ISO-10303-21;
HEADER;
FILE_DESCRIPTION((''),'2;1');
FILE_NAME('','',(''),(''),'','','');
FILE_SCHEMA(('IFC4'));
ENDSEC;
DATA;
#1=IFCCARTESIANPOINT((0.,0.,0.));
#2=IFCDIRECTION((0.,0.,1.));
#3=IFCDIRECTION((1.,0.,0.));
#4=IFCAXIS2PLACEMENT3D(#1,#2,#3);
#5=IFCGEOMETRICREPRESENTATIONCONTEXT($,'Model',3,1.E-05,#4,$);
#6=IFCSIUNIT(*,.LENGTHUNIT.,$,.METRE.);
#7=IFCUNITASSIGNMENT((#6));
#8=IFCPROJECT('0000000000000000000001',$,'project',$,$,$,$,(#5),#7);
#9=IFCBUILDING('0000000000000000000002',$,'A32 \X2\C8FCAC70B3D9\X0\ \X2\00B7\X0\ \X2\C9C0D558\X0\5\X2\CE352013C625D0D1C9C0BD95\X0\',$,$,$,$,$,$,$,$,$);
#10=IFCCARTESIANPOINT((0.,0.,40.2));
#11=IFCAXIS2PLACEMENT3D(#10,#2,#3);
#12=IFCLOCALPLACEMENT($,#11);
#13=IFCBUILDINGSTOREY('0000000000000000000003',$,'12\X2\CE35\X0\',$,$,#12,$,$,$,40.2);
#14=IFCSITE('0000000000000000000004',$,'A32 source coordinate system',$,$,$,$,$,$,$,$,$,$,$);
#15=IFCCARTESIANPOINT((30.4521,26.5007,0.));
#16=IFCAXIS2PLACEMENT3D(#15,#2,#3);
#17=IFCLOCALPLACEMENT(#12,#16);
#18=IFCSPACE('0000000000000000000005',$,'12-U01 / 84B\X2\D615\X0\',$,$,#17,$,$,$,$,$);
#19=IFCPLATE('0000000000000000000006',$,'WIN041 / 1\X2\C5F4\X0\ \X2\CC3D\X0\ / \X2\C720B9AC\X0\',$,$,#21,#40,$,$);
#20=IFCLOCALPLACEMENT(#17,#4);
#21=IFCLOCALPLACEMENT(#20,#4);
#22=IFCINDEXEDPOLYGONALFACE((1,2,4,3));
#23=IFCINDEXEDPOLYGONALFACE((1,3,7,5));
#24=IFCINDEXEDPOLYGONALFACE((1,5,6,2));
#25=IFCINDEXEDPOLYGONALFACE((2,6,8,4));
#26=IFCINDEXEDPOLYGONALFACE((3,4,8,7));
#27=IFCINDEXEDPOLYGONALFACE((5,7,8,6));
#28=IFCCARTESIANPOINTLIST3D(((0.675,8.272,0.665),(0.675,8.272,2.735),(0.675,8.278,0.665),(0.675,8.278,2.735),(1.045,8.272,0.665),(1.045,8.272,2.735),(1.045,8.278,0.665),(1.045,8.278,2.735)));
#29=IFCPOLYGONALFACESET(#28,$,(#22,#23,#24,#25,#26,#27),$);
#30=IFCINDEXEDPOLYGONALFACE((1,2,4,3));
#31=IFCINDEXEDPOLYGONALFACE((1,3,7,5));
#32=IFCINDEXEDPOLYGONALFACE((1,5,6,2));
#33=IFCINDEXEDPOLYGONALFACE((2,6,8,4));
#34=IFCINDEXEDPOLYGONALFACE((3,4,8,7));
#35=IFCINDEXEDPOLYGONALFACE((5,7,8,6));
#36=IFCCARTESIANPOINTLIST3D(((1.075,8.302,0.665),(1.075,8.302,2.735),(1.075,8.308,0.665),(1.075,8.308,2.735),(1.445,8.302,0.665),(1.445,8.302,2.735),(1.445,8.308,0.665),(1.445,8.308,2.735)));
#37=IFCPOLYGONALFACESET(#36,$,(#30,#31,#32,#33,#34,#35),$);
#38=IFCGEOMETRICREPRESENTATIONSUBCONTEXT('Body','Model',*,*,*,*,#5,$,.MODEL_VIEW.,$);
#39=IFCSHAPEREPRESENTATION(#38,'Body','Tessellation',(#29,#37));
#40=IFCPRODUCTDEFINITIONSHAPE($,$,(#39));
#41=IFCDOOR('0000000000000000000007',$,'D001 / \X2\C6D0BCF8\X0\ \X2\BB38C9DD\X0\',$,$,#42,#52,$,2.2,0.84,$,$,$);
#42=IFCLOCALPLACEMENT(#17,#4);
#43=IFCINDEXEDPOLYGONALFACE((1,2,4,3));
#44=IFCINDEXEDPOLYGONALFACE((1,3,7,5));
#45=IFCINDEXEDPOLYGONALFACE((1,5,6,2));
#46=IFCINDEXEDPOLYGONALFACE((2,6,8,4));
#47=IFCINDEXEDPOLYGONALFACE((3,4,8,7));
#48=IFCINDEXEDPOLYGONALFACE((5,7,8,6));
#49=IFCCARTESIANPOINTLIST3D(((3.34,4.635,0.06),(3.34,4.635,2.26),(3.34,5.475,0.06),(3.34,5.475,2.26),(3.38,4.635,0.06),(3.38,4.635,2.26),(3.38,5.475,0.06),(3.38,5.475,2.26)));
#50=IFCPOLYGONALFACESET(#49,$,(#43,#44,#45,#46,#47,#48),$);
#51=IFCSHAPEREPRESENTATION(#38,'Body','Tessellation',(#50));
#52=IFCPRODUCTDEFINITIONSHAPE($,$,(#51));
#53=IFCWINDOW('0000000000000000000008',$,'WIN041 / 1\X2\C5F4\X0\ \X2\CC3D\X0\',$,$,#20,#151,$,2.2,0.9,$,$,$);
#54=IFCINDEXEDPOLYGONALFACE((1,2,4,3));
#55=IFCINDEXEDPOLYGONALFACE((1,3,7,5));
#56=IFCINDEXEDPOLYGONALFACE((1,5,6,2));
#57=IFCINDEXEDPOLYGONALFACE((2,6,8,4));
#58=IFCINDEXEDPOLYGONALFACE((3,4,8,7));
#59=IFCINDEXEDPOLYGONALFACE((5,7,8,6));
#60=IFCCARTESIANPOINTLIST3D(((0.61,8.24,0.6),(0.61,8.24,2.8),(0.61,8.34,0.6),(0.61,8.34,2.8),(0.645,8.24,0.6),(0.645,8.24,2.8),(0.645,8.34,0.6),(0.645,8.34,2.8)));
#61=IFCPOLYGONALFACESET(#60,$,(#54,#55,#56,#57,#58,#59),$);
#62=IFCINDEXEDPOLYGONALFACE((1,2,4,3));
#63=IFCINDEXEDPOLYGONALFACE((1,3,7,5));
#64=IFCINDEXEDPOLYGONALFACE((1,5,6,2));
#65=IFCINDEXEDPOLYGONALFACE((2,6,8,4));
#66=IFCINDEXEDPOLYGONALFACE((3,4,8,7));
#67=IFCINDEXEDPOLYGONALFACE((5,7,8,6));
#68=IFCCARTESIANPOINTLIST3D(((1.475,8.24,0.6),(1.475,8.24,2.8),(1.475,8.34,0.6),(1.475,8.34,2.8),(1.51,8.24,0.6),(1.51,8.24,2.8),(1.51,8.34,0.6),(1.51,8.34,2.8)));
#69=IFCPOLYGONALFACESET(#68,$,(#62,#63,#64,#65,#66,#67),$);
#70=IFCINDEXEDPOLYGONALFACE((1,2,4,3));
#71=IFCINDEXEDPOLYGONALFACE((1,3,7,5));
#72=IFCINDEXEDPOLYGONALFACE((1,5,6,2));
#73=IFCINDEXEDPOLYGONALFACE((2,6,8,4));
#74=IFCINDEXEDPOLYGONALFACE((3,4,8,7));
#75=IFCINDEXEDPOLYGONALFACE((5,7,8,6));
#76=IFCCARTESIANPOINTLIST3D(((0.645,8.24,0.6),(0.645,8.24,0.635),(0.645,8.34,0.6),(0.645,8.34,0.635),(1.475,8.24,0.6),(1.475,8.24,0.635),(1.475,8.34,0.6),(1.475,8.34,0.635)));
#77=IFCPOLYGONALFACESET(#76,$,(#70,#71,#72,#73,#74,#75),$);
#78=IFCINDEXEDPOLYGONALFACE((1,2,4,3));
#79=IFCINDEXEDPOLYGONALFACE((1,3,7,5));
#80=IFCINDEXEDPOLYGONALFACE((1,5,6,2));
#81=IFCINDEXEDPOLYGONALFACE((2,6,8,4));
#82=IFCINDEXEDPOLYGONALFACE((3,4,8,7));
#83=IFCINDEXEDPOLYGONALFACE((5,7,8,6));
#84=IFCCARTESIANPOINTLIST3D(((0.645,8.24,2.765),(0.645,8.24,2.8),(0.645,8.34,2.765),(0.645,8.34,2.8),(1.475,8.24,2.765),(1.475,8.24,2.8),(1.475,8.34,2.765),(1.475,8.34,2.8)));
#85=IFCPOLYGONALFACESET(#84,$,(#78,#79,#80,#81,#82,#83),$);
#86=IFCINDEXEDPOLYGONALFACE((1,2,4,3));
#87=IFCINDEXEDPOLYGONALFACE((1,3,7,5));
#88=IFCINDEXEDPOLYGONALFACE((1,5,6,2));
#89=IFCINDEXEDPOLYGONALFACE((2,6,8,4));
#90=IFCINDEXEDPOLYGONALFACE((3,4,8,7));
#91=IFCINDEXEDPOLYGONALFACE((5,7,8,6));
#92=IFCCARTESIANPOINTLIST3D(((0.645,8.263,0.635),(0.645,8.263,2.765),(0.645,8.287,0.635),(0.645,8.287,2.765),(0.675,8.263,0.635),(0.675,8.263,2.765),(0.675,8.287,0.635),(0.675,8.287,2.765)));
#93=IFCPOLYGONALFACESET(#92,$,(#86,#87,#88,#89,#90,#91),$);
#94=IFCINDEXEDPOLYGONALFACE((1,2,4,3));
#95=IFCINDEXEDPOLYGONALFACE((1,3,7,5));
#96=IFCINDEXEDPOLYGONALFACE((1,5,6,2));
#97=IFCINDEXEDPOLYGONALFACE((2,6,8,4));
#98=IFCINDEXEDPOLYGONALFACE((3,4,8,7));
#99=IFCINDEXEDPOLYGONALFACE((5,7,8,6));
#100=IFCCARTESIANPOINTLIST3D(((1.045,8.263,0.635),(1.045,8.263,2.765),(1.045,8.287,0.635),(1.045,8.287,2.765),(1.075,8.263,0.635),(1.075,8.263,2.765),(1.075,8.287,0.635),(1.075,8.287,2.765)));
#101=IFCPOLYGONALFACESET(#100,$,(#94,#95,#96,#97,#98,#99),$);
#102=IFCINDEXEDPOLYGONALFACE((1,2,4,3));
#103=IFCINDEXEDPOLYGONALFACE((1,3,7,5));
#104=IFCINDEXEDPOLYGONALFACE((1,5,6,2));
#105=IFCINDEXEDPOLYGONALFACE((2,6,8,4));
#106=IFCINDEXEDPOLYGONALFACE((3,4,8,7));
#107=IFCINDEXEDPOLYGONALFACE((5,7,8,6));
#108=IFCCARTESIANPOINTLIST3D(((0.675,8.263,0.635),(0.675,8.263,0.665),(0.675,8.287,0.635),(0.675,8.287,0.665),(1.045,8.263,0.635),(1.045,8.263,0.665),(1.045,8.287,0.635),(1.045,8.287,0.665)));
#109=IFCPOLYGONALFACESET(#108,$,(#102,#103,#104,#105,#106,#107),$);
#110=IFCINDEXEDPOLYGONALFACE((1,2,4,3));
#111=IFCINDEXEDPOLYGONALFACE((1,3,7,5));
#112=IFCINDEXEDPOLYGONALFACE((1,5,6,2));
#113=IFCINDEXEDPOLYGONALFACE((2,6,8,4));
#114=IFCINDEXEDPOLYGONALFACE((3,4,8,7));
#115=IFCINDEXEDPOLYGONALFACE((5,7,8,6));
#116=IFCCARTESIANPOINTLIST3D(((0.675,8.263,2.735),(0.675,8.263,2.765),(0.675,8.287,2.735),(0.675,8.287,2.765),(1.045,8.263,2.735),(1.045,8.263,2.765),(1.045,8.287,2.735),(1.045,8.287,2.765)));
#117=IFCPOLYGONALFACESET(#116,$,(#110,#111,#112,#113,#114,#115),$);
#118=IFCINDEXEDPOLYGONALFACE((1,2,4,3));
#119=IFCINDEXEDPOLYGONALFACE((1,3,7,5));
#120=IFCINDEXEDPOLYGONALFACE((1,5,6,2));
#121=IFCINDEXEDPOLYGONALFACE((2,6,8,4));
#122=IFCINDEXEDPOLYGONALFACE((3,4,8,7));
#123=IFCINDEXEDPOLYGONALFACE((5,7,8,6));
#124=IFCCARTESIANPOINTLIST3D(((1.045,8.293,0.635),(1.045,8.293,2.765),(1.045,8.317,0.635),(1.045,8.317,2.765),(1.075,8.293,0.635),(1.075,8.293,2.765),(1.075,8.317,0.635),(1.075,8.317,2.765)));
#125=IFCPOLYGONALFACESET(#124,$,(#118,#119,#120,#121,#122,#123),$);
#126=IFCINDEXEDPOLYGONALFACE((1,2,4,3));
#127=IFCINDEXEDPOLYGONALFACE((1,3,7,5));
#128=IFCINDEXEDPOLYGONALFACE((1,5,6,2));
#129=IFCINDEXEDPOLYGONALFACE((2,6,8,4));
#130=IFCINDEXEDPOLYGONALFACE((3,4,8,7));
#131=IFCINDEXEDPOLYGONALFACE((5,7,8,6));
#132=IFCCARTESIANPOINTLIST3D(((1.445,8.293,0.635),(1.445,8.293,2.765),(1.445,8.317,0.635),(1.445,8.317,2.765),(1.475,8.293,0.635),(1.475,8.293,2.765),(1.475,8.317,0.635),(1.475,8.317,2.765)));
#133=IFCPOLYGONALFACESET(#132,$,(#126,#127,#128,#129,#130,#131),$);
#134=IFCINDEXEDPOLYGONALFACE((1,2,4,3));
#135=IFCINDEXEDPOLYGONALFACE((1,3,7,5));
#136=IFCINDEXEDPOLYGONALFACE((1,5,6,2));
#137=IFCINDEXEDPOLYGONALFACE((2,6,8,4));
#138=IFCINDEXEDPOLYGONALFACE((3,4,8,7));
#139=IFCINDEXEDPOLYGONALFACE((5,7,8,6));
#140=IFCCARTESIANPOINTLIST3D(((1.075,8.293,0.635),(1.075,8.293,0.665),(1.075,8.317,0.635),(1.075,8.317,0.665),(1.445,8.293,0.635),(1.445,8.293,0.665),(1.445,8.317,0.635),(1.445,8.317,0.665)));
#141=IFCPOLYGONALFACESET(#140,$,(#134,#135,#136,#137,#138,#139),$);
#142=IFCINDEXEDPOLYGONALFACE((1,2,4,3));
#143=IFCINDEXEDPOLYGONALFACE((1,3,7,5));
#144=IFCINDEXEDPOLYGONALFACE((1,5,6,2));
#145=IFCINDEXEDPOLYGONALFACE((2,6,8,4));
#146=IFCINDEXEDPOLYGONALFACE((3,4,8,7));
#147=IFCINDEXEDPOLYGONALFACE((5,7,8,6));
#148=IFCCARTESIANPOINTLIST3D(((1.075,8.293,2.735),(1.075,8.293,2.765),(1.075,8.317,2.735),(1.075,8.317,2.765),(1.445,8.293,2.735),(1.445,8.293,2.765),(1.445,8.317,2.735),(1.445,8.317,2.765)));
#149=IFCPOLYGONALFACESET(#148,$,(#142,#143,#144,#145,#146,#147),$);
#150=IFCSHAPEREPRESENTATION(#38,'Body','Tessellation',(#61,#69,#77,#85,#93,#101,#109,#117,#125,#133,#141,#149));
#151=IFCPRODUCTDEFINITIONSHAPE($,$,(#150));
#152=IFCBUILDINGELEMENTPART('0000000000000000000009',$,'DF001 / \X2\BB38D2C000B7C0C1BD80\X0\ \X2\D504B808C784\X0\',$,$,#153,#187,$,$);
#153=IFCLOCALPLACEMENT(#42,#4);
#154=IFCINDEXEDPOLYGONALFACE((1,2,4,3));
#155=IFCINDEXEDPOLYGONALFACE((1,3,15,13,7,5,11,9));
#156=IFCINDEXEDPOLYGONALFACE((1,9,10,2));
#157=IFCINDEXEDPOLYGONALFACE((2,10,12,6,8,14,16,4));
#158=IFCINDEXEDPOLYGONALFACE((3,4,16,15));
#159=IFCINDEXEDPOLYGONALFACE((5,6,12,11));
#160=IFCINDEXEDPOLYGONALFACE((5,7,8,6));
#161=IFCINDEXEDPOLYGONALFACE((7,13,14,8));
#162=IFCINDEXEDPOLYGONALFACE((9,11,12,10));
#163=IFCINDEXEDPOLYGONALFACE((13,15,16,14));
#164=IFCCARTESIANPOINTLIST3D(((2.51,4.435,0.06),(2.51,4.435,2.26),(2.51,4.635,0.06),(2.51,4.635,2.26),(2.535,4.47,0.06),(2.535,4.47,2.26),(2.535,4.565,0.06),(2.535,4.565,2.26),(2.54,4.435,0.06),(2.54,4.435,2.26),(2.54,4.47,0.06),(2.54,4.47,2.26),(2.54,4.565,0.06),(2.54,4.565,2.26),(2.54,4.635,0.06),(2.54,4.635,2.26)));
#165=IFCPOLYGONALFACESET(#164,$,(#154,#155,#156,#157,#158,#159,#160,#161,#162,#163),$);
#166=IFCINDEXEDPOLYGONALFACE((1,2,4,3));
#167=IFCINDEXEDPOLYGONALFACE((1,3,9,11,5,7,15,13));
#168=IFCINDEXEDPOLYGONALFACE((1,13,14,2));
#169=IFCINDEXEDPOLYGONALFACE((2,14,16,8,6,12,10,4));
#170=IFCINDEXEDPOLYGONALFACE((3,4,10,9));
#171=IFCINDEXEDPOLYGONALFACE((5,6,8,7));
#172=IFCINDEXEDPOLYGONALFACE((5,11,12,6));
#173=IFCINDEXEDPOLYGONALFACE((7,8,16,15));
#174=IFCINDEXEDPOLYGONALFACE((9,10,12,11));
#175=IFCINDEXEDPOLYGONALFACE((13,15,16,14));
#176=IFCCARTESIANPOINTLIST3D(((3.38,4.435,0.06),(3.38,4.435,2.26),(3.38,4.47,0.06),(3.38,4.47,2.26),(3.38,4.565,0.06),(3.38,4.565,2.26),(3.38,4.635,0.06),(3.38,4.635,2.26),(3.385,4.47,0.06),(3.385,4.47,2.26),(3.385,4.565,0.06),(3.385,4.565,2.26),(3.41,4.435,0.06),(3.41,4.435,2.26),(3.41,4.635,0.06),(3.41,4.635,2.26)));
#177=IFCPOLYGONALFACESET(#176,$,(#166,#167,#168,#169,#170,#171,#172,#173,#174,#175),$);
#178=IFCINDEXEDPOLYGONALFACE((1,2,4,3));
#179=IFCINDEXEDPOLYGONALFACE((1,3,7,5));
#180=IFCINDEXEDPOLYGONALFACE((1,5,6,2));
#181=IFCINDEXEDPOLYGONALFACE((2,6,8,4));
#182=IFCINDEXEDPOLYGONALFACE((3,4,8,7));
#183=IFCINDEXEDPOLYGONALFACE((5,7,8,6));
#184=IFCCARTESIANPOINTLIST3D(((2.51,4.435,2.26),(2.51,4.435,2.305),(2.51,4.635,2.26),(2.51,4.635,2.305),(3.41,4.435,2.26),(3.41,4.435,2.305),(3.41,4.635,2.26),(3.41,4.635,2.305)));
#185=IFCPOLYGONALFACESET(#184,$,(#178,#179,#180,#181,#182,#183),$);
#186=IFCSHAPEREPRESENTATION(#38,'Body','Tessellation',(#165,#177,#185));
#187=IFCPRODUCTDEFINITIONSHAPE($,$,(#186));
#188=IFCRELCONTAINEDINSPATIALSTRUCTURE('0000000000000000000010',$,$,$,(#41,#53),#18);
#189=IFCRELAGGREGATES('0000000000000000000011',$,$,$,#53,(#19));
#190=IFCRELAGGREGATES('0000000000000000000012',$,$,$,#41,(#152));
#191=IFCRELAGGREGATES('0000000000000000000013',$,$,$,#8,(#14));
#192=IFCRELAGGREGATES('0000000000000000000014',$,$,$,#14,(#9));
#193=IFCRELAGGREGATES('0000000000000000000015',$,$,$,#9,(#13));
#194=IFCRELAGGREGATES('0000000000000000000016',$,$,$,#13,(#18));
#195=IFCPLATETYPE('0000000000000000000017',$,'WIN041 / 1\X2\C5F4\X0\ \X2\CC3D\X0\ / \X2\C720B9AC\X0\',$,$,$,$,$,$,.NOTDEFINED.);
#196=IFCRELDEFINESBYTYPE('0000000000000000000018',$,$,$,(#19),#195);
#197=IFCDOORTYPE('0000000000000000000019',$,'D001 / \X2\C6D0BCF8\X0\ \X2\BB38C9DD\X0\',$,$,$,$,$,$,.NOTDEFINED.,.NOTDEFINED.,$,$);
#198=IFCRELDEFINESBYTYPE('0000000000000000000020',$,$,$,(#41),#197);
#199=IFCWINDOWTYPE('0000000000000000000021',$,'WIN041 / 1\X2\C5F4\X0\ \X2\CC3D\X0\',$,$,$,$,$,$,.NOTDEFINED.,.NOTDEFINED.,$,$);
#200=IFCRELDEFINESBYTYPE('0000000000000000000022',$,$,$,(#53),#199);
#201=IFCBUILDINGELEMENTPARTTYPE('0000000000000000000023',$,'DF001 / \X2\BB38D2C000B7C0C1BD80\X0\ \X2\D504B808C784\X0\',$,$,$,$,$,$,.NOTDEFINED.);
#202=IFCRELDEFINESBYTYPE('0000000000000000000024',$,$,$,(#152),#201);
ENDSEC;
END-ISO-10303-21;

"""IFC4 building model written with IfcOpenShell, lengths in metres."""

from ifc_helpers import new_model, si_unit, frame, origin, origin_with_axes, place, context, subcontext, project, spatial, polyline, outline, extrude, source, transform, mapped, type_object, type_shapes, element, aggregate, save


model = new_model("IFC4")

# Units and contexts
model_context = context("Model", 3, precision=1e-05, world=origin_with_axes())
body_context = subcontext(model_context, "Body", "Model", "MODEL_VIEW")
ifc_project = project(units=[si_unit("LENGTHUNIT", "METRE")], contexts=[model_context])

# Plate
storey_placement = place(None, frame((0.0, 0.0, 40.2), z_axis=(0.0, 0.0, 1.0), x_axis=(1.0, 0.0, 0.0)))
space_placement = place(storey_placement, frame((30.4521, 26.5007, 0.0), z_axis=(0.0, 0.0, 1.0), x_axis=(1.0, 0.0, 0.0)))
plate_type_1 = type_object("IfcPlateType", Name="WIN041 / 1열 창 / 유리", PredefinedType="NOTDEFINED")
shared_shape_1 = source(origin(), body_context, "Body", "SweptSolid", [
    extrude(outline(polyline([(0.675, 8.272), (0.675, 8.278), (1.045, 8.278), (1.045, 8.272), (0.675, 8.272)])), frame((0.0, 0.0, 0.665)), (0.0, 0.0, 1.0), 2.07),
    extrude(outline(polyline([(1.075, 8.302), (1.075, 8.308), (1.445, 8.308), (1.445, 8.302), (1.075, 8.302)])), frame((0.0, 0.0, 0.665)), (0.0, 0.0, 1.0), 2.07),
])
type_shapes(plate_type_1, [shared_shape_1])
window_1_placement = place(space_placement, origin_with_axes())
plate_1_placement = place(window_1_placement, origin_with_axes())
plate_1 = element("IfcPlate", 1, at=plate_1_placement, type_object=plate_type_1, Name="WIN041 / 1열 창 / 유리", context=body_context, shape_type="MappedRepresentation", body=[
    mapped(shared_shape_1, transform((0.0, 0.0, 0.0), scale=1.0)),
])

# Site, building, storey, space
site = spatial("IfcSite", under=ifc_project, Name="A32 source coordinate system")
building = spatial("IfcBuilding", under=site, Name="A32 주거동 · 지하5층–옥탑지붕")
storey = spatial("IfcBuildingStorey", under=building, at=storey_placement, Name="12층", Elevation=40.2)
space = spatial("IfcSpace", under=storey, at=space_placement, Name="12-U01 / 84B형")

# Door
door_type_1 = type_object("IfcDoorType", Name="D001 / 원본 문짝", OperationType="NOTDEFINED", PredefinedType="NOTDEFINED")
shared_shape_2 = source(origin(), body_context, "Body", "SweptSolid", [
    extrude(outline(polyline([(3.34, 5.475), (3.38, 5.475), (3.38, 4.635), (3.34, 4.635), (3.34, 5.475)])), frame((0.0, 0.0, 0.06)), (0.0, 0.0, 1.0), 2.2),
])
type_shapes(door_type_1, [shared_shape_2])
door_1_placement = place(space_placement, origin_with_axes())
door_1 = element("IfcDoor", 2, at=door_1_placement, inside=space, type_object=door_type_1, Name="D001 / 원본 문짝", OverallHeight=2.2, OverallWidth=0.84, context=body_context, shape_type="MappedRepresentation", body=[
    mapped(shared_shape_2, transform((0.0, 0.0, 0.0), scale=1.0)),
])

# Window
window_type_1 = type_object("IfcWindowType", Name="WIN041 / 1열 창", PartitioningType="NOTDEFINED", PredefinedType="NOTDEFINED")
shared_shape_3 = source(origin(), body_context, "Body", "SweptSolid", [
    extrude(outline(polyline([(0.61, 8.24), (0.61, 8.34), (0.645, 8.34), (0.645, 8.24), (0.61, 8.24)])), frame((0.0, 0.0, 0.6)), (0.0, 0.0, 1.0), 2.2),
    extrude(outline(polyline([(1.475, 8.24), (1.475, 8.34), (1.51, 8.34), (1.51, 8.24), (1.475, 8.24)])), frame((0.0, 0.0, 0.6)), (0.0, 0.0, 1.0), 2.2),
    extrude(outline(polyline([(0.645, 8.24), (0.645, 8.34), (1.475, 8.34), (1.475, 8.24), (0.645, 8.24)])), frame((0.0, 0.0, 0.6)), (0.0, 0.0, 1.0), 0.035),
    extrude(outline(polyline([(0.645, 8.24), (0.645, 8.34), (1.475, 8.34), (1.475, 8.24), (0.645, 8.24)])), frame((0.0, 0.0, 2.765)), (0.0, 0.0, 1.0), 0.035),
    extrude(outline(polyline([(0.645, 8.263), (0.645, 8.287), (0.675, 8.287), (0.675, 8.263), (0.645, 8.263)])), frame((0.0, 0.0, 0.635)), (0.0, 0.0, 1.0), 2.13),
    extrude(outline(polyline([(1.045, 8.263), (1.045, 8.287), (1.075, 8.287), (1.075, 8.263), (1.045, 8.263)])), frame((0.0, 0.0, 0.635)), (0.0, 0.0, 1.0), 2.13),
    extrude(outline(polyline([(0.675, 8.263), (0.675, 8.287), (1.045, 8.287), (1.045, 8.263), (0.675, 8.263)])), frame((0.0, 0.0, 0.635)), (0.0, 0.0, 1.0), 0.03),
    extrude(outline(polyline([(0.675, 8.263), (0.675, 8.287), (1.045, 8.287), (1.045, 8.263), (0.675, 8.263)])), frame((0.0, 0.0, 2.735)), (0.0, 0.0, 1.0), 0.03),
    extrude(outline(polyline([(1.045, 8.293), (1.045, 8.317), (1.075, 8.317), (1.075, 8.293), (1.045, 8.293)])), frame((0.0, 0.0, 0.635)), (0.0, 0.0, 1.0), 2.13),
    extrude(outline(polyline([(1.445, 8.293), (1.445, 8.317), (1.475, 8.317), (1.475, 8.293), (1.445, 8.293)])), frame((0.0, 0.0, 0.635)), (0.0, 0.0, 1.0), 2.13),
    extrude(outline(polyline([(1.075, 8.293), (1.075, 8.317), (1.445, 8.317), (1.445, 8.293), (1.075, 8.293)])), frame((0.0, 0.0, 0.635)), (0.0, 0.0, 1.0), 0.03),
    extrude(outline(polyline([(1.075, 8.293), (1.075, 8.317), (1.445, 8.317), (1.445, 8.293), (1.075, 8.293)])), frame((0.0, 0.0, 2.735)), (0.0, 0.0, 1.0), 0.03),
])
type_shapes(window_type_1, [shared_shape_3])
window_1 = element("IfcWindow", 3, at=window_1_placement, inside=space, type_object=window_type_1, Name="WIN041 / 1열 창", OverallHeight=2.2, OverallWidth=0.9, context=body_context, shape_type="MappedRepresentation", body=[
    mapped(shared_shape_3, transform((0.0, 0.0, 0.0), scale=1.0)),
])
aggregate(window_1, [plate_1])

# Building element part
building_element_part_type_1 = type_object("IfcBuildingElementPartType", Name="DF001 / 문틀·상부 프레임", PredefinedType="NOTDEFINED")
shared_shape_4 = source(origin(), body_context, "Body", "SweptSolid", [
    extrude(outline(polyline([(2.54, 4.635), (2.54, 4.565), (2.535, 4.565), (2.535, 4.47), (2.54, 4.47), (2.54, 4.435), (2.51, 4.435), (2.51, 4.635), (2.54, 4.635)])), frame((0.0, 0.0, 0.06)), (0.0, 0.0, 1.0), 2.2),
    extrude(outline(polyline([(3.41, 4.435), (3.38, 4.435), (3.38, 4.47), (3.385, 4.47), (3.385, 4.565), (3.38, 4.565), (3.38, 4.635), (3.41, 4.635), (3.41, 4.435)])), frame((0.0, 0.0, 0.06)), (0.0, 0.0, 1.0), 2.2),
    extrude(outline(polyline([(2.51, 4.435), (2.51, 4.635), (3.41, 4.635), (3.41, 4.435), (2.51, 4.435)])), frame((0.0, 0.0, 2.26)), (0.0, 0.0, 1.0), 0.045),
])
type_shapes(building_element_part_type_1, [shared_shape_4])
building_element_part_1_placement = place(door_1_placement, origin_with_axes())
building_element_part_1 = element("IfcBuildingElementPart", 4, at=building_element_part_1_placement, type_object=building_element_part_type_1, Name="DF001 / 문틀·상부 프레임", context=body_context, shape_type="MappedRepresentation", body=[
    mapped(shared_shape_4, transform((0.0, 0.0, 0.0), scale=1.0)),
])
aggregate(door_1, [building_element_part_1])

save(model, "model.ifc")
